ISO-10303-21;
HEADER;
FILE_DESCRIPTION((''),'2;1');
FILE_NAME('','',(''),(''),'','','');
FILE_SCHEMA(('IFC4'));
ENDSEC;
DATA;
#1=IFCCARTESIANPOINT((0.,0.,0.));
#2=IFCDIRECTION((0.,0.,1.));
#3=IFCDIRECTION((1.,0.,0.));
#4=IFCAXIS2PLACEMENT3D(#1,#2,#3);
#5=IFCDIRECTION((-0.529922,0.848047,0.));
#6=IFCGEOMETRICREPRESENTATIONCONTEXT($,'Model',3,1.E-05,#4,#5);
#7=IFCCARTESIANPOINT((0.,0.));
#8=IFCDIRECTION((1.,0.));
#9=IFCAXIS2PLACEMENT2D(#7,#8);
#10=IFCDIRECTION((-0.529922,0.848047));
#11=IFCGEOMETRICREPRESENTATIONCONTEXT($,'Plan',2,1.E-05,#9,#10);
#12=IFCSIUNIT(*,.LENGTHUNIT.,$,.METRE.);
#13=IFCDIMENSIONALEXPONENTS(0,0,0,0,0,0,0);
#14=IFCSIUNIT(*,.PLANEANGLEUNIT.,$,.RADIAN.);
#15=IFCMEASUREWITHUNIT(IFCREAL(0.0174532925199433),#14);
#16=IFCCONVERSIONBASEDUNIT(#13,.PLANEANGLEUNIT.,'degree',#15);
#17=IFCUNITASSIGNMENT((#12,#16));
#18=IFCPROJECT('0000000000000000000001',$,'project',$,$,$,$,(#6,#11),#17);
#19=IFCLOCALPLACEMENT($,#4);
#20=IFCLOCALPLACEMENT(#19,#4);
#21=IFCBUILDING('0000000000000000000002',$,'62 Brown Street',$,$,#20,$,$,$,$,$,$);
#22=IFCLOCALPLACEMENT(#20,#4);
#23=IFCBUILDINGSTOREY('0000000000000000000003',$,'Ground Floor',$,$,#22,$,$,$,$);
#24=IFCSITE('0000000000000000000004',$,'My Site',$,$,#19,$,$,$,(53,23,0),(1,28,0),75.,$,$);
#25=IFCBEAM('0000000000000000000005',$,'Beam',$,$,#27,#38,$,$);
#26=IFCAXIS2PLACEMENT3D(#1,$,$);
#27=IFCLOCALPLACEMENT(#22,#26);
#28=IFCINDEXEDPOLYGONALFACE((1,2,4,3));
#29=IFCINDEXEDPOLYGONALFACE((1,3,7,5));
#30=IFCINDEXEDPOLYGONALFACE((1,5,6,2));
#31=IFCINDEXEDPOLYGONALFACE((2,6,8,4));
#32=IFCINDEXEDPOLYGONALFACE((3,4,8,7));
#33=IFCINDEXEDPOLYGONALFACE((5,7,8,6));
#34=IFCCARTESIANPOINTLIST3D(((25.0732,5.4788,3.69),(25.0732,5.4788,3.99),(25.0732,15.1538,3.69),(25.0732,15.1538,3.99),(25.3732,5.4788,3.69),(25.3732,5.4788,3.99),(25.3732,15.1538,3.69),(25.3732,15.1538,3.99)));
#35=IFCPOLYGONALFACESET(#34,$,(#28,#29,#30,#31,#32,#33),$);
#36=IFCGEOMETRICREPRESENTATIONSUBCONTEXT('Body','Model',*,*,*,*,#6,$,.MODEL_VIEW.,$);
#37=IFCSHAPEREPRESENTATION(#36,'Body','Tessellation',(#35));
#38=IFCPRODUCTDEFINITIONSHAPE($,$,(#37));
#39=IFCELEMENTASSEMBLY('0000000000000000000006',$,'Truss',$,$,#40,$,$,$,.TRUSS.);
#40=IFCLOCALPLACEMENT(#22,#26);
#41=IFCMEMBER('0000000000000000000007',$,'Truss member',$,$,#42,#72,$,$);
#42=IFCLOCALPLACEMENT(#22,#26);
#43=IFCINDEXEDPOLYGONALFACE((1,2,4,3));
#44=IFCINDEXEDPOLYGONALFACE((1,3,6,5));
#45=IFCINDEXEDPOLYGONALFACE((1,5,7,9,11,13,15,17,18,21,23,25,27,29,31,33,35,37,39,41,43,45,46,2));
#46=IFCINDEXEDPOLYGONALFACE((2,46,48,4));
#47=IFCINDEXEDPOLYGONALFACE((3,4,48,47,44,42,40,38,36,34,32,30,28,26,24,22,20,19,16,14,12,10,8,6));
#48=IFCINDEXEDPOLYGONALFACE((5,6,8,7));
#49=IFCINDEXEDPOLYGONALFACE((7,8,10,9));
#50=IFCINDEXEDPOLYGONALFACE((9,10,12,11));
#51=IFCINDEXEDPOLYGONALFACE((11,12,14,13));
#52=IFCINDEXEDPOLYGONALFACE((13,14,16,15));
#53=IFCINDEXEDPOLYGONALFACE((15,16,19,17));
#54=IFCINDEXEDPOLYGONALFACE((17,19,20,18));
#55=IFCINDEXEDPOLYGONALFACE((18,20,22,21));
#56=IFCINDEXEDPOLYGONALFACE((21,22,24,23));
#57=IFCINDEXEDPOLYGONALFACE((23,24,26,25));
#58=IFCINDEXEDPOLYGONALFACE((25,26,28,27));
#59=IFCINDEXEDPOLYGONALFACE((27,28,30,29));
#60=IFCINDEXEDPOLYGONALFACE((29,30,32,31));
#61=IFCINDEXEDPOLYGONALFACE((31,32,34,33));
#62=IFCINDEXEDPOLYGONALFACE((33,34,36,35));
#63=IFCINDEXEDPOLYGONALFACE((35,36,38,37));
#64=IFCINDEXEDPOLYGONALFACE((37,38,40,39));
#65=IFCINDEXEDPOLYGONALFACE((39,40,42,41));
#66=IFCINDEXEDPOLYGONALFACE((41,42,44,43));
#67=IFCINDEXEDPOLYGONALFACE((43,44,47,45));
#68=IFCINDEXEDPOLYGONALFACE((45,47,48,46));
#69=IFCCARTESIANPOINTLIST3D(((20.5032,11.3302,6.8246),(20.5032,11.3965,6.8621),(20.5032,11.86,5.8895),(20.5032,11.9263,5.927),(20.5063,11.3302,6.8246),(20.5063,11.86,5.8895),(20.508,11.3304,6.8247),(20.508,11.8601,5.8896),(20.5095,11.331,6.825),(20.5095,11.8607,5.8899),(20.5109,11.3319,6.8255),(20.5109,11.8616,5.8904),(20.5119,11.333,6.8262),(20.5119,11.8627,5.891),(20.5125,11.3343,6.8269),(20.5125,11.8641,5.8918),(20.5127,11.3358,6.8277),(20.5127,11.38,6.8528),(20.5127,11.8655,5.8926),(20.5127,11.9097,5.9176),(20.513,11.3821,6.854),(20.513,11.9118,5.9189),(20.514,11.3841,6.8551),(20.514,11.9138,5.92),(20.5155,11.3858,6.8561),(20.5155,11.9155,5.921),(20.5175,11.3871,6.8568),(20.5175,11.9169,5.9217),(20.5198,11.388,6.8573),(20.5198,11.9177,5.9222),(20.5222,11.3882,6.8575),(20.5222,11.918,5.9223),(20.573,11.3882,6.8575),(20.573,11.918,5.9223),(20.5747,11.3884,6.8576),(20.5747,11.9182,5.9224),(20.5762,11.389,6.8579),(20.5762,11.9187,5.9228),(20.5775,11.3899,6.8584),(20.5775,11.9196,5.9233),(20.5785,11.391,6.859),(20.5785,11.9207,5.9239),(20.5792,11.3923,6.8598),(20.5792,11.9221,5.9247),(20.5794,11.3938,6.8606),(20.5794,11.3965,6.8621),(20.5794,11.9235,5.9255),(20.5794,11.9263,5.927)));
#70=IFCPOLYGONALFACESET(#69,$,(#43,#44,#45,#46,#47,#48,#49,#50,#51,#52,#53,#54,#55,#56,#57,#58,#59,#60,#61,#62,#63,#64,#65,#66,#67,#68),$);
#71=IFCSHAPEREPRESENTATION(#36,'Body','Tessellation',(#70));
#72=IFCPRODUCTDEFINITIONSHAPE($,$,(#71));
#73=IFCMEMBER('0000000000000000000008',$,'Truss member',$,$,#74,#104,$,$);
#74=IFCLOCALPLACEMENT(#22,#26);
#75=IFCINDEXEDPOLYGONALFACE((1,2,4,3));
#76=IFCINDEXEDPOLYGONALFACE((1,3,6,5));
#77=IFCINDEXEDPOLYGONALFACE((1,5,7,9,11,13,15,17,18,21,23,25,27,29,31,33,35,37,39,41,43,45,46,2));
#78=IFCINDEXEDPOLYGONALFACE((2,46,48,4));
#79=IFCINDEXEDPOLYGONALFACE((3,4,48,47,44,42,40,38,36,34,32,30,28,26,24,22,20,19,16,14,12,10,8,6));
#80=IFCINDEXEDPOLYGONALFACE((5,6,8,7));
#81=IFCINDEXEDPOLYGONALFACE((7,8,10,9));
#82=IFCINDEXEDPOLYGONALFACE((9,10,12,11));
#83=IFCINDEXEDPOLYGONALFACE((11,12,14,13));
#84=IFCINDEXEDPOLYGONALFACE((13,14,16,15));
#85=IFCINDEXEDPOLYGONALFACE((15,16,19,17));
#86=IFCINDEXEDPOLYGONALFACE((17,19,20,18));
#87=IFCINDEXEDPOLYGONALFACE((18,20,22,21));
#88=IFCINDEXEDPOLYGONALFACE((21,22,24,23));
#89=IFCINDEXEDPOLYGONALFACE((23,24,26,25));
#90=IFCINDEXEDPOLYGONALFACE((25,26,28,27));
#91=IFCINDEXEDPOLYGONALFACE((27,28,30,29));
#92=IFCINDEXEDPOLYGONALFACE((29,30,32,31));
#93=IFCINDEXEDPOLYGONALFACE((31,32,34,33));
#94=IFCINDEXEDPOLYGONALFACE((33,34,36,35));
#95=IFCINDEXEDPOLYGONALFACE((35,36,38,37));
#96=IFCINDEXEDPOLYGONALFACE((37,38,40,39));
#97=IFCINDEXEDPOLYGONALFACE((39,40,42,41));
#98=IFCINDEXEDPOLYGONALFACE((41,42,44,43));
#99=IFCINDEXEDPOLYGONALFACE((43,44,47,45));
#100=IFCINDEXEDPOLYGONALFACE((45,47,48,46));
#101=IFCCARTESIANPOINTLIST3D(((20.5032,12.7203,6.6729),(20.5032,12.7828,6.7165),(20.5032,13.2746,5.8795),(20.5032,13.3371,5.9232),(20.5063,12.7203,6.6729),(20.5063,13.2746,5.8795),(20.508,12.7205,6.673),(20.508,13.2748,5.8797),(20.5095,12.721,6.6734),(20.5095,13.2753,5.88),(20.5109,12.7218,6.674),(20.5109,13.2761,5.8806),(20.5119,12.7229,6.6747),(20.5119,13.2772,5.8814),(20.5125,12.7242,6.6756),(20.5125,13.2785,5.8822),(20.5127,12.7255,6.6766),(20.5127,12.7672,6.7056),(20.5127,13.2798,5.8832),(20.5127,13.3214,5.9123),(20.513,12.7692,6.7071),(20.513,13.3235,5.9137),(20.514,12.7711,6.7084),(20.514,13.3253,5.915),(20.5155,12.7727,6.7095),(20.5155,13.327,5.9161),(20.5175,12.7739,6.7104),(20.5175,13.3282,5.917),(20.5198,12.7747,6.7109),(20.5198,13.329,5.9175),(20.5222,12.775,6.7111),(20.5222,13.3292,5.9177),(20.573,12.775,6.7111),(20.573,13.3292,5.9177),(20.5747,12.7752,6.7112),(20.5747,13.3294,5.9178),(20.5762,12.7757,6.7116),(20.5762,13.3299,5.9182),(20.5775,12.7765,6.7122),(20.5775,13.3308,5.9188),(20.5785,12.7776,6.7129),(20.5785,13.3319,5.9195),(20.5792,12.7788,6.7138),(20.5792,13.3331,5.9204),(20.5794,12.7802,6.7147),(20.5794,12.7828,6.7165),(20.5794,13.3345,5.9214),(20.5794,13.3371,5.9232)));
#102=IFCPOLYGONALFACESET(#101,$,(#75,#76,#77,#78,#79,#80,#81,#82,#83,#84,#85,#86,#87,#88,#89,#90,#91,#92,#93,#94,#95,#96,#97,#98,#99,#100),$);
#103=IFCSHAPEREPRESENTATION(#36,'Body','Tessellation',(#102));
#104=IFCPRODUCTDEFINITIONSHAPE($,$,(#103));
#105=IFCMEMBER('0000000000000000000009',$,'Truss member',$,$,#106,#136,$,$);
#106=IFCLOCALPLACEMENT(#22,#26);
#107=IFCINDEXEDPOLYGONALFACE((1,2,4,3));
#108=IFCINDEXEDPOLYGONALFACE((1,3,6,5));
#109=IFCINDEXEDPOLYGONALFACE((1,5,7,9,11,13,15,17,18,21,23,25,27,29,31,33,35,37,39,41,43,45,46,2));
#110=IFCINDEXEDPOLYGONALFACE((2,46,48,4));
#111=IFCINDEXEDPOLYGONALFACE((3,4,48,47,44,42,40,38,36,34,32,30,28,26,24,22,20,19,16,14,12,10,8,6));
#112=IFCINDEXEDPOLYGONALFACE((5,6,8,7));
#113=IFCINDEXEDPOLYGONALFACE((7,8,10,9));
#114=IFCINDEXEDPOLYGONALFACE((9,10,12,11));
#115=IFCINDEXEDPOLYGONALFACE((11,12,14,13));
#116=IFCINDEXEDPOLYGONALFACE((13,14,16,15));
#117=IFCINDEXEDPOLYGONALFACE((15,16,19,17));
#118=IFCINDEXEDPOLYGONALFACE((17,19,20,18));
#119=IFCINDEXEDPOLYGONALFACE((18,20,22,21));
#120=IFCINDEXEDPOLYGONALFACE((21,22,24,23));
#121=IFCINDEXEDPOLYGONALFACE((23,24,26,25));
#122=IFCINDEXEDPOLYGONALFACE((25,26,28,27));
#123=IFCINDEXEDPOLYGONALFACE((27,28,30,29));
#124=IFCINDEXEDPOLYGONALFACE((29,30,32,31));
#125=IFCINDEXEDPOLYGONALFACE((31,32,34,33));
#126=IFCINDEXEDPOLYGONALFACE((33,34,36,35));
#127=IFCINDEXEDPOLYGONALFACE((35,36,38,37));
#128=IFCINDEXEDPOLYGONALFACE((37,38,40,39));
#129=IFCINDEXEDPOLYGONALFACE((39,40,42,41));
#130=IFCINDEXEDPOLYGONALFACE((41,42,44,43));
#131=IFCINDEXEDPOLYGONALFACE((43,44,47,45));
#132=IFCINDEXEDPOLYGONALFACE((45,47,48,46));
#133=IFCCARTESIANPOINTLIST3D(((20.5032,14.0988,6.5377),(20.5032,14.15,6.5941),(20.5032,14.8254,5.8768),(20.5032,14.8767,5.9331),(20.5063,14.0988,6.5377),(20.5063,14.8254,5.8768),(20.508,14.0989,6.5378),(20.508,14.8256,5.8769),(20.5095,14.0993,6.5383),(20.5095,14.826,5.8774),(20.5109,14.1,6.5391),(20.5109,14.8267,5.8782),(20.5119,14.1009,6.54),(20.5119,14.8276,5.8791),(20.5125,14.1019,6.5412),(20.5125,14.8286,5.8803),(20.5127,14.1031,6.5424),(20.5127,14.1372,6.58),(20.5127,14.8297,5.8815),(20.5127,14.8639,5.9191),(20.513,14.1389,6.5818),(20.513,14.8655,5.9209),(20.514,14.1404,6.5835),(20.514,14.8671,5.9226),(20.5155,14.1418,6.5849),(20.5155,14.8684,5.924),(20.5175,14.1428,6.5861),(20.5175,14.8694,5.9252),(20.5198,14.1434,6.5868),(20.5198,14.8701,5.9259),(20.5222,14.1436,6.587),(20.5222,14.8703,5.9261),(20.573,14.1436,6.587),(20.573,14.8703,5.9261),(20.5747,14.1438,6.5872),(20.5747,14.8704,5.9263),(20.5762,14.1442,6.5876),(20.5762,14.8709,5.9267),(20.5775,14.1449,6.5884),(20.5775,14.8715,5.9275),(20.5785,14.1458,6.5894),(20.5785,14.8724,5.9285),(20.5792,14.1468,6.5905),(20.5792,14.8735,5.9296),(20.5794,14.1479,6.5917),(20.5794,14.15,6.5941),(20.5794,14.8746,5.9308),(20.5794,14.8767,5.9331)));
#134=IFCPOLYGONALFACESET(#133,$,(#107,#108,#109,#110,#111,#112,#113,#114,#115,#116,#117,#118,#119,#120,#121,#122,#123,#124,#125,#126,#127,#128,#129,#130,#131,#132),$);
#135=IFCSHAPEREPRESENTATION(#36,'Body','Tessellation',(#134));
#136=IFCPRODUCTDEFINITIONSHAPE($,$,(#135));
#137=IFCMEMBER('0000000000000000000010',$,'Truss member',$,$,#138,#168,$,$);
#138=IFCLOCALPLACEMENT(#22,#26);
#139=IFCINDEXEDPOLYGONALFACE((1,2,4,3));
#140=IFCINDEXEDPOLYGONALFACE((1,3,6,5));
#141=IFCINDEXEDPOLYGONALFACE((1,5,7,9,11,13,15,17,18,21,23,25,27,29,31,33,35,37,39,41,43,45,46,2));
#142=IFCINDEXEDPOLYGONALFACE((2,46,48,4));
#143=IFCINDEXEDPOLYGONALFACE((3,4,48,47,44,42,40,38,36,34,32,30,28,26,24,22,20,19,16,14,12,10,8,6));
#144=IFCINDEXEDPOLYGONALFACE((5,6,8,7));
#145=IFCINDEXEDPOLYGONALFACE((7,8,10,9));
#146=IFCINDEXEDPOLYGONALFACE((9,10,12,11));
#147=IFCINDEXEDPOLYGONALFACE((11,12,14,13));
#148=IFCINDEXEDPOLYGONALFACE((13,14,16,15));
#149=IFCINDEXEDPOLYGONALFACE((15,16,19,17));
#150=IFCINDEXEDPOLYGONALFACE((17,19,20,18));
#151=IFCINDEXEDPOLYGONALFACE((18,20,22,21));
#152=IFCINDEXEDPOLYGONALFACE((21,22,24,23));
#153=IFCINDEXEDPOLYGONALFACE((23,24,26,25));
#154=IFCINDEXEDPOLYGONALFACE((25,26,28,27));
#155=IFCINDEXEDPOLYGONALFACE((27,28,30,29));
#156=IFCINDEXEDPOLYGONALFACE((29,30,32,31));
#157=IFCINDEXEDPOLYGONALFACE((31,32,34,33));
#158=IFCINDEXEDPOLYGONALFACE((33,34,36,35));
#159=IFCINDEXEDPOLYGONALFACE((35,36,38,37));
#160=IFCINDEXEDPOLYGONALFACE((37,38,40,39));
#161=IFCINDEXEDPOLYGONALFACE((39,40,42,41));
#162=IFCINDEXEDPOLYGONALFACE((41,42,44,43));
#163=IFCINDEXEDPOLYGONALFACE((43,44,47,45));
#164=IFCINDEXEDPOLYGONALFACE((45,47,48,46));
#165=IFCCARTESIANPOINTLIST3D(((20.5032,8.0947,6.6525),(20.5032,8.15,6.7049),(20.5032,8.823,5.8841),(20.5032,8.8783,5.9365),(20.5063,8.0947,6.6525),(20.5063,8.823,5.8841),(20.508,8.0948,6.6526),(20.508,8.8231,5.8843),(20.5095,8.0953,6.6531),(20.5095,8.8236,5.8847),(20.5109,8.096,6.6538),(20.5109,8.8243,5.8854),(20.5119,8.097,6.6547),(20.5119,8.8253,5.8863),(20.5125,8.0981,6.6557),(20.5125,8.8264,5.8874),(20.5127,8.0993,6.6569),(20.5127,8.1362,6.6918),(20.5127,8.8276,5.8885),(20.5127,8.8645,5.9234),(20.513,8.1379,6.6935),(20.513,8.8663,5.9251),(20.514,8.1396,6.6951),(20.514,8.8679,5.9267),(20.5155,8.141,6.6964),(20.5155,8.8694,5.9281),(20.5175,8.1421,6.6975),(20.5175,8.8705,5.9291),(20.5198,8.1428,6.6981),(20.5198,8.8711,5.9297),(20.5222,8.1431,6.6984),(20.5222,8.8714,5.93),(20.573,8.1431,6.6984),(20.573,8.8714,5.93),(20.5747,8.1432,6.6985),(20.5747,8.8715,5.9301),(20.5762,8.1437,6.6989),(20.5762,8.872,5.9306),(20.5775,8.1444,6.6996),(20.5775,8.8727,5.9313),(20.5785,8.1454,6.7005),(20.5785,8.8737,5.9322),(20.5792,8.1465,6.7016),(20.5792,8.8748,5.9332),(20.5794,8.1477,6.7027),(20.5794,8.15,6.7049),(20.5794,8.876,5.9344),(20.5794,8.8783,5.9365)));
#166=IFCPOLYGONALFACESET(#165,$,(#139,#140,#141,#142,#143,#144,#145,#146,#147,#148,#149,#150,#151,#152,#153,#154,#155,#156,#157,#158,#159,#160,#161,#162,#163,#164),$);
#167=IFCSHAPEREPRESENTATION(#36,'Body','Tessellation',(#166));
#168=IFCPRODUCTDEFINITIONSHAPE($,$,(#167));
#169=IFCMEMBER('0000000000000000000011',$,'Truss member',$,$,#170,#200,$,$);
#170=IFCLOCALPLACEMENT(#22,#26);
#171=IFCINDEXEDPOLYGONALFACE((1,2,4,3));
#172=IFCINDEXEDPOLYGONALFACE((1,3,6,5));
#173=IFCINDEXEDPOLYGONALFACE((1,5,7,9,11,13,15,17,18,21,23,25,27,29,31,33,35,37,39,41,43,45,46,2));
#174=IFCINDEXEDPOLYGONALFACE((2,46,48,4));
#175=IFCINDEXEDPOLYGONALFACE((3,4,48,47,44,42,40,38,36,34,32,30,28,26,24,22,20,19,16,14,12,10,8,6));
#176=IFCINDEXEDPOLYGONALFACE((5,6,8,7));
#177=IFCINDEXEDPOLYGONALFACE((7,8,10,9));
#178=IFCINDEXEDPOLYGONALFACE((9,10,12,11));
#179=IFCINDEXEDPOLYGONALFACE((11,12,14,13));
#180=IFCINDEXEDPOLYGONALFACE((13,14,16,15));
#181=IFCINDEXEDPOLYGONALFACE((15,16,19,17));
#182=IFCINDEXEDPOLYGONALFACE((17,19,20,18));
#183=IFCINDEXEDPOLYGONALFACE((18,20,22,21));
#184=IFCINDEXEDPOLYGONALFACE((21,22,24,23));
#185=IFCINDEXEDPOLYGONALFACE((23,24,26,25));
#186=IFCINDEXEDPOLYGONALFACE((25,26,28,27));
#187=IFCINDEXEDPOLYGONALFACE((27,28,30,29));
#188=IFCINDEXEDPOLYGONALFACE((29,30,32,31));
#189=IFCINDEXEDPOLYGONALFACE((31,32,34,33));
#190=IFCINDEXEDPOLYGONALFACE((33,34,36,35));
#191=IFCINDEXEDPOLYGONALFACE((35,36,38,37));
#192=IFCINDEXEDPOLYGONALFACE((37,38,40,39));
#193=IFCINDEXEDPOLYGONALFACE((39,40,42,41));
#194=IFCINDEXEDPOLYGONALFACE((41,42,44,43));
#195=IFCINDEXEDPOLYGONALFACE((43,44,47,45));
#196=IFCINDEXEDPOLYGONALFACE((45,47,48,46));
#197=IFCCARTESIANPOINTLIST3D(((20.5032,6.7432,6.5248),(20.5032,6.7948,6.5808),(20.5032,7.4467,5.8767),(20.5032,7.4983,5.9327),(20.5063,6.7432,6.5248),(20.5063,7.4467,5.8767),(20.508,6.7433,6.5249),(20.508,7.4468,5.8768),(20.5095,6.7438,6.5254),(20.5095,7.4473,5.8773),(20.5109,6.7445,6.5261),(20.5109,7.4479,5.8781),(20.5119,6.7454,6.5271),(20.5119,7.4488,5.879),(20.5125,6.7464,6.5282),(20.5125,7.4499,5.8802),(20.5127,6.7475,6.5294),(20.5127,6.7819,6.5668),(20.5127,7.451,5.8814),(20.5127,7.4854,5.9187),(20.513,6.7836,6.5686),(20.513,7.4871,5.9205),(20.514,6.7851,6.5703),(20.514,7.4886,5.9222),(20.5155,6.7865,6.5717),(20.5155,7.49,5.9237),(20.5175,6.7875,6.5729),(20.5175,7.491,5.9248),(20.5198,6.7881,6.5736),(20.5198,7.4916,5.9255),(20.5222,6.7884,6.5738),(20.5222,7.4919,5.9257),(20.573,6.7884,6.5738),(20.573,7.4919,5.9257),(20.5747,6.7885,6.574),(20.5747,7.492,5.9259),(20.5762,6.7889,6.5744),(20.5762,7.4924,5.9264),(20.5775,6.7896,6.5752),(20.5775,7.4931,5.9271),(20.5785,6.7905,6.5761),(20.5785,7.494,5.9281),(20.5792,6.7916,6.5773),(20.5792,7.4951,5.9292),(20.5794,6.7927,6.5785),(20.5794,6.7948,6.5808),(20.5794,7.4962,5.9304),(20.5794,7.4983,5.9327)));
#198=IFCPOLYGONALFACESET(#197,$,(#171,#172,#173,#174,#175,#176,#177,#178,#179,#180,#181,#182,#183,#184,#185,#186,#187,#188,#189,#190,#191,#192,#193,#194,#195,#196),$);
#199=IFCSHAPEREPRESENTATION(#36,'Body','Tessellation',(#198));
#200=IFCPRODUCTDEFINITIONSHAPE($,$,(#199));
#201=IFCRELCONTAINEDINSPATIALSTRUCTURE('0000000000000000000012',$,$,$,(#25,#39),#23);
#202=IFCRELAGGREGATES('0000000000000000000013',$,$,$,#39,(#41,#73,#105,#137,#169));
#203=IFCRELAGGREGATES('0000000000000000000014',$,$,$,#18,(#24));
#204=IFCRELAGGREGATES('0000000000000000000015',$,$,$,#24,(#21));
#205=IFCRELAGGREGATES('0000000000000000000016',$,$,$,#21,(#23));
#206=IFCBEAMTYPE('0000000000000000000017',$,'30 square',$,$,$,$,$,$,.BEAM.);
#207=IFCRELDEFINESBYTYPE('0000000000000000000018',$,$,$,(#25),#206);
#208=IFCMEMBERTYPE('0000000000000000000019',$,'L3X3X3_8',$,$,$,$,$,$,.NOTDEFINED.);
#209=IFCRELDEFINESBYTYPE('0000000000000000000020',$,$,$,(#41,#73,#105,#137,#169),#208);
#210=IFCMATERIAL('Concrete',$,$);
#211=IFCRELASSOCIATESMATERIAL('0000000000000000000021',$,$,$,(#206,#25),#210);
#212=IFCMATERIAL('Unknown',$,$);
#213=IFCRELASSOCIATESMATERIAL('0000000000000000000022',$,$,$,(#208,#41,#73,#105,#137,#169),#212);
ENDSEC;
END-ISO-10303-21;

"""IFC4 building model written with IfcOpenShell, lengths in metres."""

from ifc_helpers import new_model, entity, si_unit, converted_unit, direction, frame, origin_with_axes, origin_2d_with_axis, place, context, subcontext, project, spatial, rectangle, l_section, extrude, material, material_profile, profile_set, profile_usage, type_object, element, aggregate, save


model = new_model("IFC4")

# Units and contexts
model_context = context("Model", 3, precision=1e-05, world=origin_with_axes(), true_north=direction((-0.529922, 0.848047, 0.0)))
plan_context = context("Plan", 2, precision=1e-05, world=origin_2d_with_axis(), true_north=direction((-0.529922, 0.848047)))
body_context = subcontext(model_context, "Body", "Model", "MODEL_VIEW")
ifc_project = project(units=[si_unit("LENGTHUNIT", "METRE"), converted_unit("PLANEANGLEUNIT", "degree", entity("IfcReal", 0.0174532925199433), si_unit("PLANEANGLEUNIT", "RADIAN"), dimensions=[0, 0, 0, 0, 0, 0, 0])], contexts=[model_context, plan_context])

# Site, building, storey
site_placement = place(None, origin_with_axes())
site = spatial("IfcSite", under=ifc_project, at=site_placement, Name="My Site", RefLatitude=(53, 23, 0), RefLongitude=(1, 28, 0), RefElevation=75.0)
building_placement = place(site_placement, origin_with_axes())
building = spatial("IfcBuilding", under=site, at=building_placement, Name="62 Brown Street")
storey_placement = place(building_placement, origin_with_axes())
storey = spatial("IfcBuildingStorey", under=building, at=storey_placement, Name="Ground Floor")

# Shared definitions
ifc_material_1 = material(Name="Concrete")

# Beam
ifc_material_profile_1 = material_profile(ifc_material_1, rectangle(XDim=0.3, YDim=0.3))
ifc_profile_set_1 = profile_set([ifc_material_profile_1])
ifc_profile_usage_1 = profile_usage(ifc_profile_set_1, cardinal=5)
beam_type = type_object("IfcBeamType", Name="30 square", PredefinedType="BEAM", material=ifc_profile_set_1)
beam_placement = place(storey_placement, frame((25.2232, 5.4788, 3.84), z_axis=(0.0, 1.0, 0.0), x_axis=(-1.0, 0.0, 0.0)))
element("IfcBeam", 1, at=beam_placement, inside=storey, type_object=beam_type, material=ifc_profile_usage_1, Name="Beam", context=body_context, shape_type="SweptSolid", body=[
    extrude(rectangle(XDim=0.3, YDim=0.3), origin_with_axes(), (0.0, 0.0, 1.0), 9.675),
])

# Element assembly, members
assembly_placement = place(storey_placement, frame((20.5032, 10.4288, 6.9738), z_axis=(0.0, 0.0, 1.0), x_axis=(1.0, 0.0, 0.0)))
assembly = element("IfcElementAssembly", 2, at=assembly_placement, inside=storey, Name="Truss", PredefinedType="TRUSS")
ifc_material_2 = material(Name="Unknown")
ifc_material_profile_2 = material_profile(ifc_material_2, l_section(Depth=0.0762, Width=0.0762, Thickness=0.0095, FilletRadius=0.0095, EdgeRadius=0.0064))
ifc_profile_set_2 = profile_set([ifc_material_profile_2])
ifc_profile_usage_2 = profile_usage(ifc_profile_set_2, cardinal=5)
member_type_1 = type_object("IfcMemberType", Name="L3X3X3_8", PredefinedType="NOTDEFINED", material=ifc_profile_set_2)
member_1_placement = place(assembly_placement, frame((0.0381, 0.9346, -0.1304), z_axis=(0.0, 0.492899, -0.870086), x_axis=(1.0, 0.0, 0.0)))
member_1 = element("IfcMember", 3, at=member_1_placement, type_object=member_type_1, material=ifc_profile_usage_2, Name="Truss member", context=body_context, shape_type="SweptSolid", body=[
    extrude(l_section(Depth=0.0762, Width=0.0762, Thickness=0.0095, FilletRadius=0.0095, EdgeRadius=0.0064), origin_with_axes(), (0.0, 0.0, 1.0), 1.0747),
])
ifc_profile_usage_3 = profile_usage(ifc_profile_set_2, cardinal=5)
member_2_placement = place(assembly_placement, frame((0.0381, 2.3228, -0.279), z_axis=(-0.000001, 0.572709, -0.819759), x_axis=(1.0, 0.0, 0.0)))
member_2 = element("IfcMember", 4, at=member_2_placement, type_object=member_type_1, material=ifc_profile_usage_3, Name="Truss member", context=body_context, shape_type="SweptSolid", body=[
    extrude(l_section(Depth=0.0762, Width=0.0762, Thickness=0.0095, FilletRadius=0.0095, EdgeRadius=0.0064), origin_with_axes(), (0.0, 0.0, 1.0), 0.9678),
])
ifc_profile_usage_4 = profile_usage(ifc_profile_set_2, cardinal=5)
member_3_placement = place(assembly_placement, frame((0.0381, 3.6956, -0.4079), z_axis=(-0.000001, 0.739785, -0.672843), x_axis=(1.0, 0.000001, 0.0)))
member_3 = element("IfcMember", 5, at=member_3_placement, type_object=member_type_1, material=ifc_profile_usage_4, Name="Truss member", context=body_context, shape_type="SweptSolid", body=[
    extrude(l_section(Depth=0.0762, Width=0.0762, Thickness=0.0095, FilletRadius=0.0095, EdgeRadius=0.0064), origin_with_axes(), (0.0, 0.0, 1.0), 0.9823),
])
ifc_profile_usage_5 = profile_usage(ifc_profile_set_2, cardinal=5)
member_4_placement = place(assembly_placement, frame((0.0381, -2.3065, -0.2951), z_axis=(-0.000001, 0.687927, -0.72578), x_axis=(1.0, 0.0, 0.0)))
member_4 = element("IfcMember", 6, at=member_4_placement, type_object=member_type_1, material=ifc_profile_usage_5, Name="Truss member", context=body_context, shape_type="SweptSolid", body=[
    extrude(l_section(Depth=0.0762, Width=0.0762, Thickness=0.0095, FilletRadius=0.0095, EdgeRadius=0.0064), origin_with_axes(), (0.0, 0.0, 1.0), 1.0587),
])
ifc_profile_usage_6 = profile_usage(ifc_profile_set_2, cardinal=5)
member_5_placement = place(assembly_placement, frame((0.0381, -3.6598, -0.421), z_axis=(-0.000001, 0.735484, -0.677542), x_axis=(1.0, 0.000001, 0.0)))
member_5 = element("IfcMember", 7, at=member_5_placement, type_object=member_type_1, material=ifc_profile_usage_6, Name="Truss member", context=body_context, shape_type="SweptSolid", body=[
    extrude(l_section(Depth=0.0762, Width=0.0762, Thickness=0.0095, FilletRadius=0.0095, EdgeRadius=0.0064), origin_with_axes(), (0.0, 0.0, 1.0), 0.9565),
])

aggregate(assembly, [member_1, member_2, member_3, member_4, member_5])

save(model, "model.ifc")
